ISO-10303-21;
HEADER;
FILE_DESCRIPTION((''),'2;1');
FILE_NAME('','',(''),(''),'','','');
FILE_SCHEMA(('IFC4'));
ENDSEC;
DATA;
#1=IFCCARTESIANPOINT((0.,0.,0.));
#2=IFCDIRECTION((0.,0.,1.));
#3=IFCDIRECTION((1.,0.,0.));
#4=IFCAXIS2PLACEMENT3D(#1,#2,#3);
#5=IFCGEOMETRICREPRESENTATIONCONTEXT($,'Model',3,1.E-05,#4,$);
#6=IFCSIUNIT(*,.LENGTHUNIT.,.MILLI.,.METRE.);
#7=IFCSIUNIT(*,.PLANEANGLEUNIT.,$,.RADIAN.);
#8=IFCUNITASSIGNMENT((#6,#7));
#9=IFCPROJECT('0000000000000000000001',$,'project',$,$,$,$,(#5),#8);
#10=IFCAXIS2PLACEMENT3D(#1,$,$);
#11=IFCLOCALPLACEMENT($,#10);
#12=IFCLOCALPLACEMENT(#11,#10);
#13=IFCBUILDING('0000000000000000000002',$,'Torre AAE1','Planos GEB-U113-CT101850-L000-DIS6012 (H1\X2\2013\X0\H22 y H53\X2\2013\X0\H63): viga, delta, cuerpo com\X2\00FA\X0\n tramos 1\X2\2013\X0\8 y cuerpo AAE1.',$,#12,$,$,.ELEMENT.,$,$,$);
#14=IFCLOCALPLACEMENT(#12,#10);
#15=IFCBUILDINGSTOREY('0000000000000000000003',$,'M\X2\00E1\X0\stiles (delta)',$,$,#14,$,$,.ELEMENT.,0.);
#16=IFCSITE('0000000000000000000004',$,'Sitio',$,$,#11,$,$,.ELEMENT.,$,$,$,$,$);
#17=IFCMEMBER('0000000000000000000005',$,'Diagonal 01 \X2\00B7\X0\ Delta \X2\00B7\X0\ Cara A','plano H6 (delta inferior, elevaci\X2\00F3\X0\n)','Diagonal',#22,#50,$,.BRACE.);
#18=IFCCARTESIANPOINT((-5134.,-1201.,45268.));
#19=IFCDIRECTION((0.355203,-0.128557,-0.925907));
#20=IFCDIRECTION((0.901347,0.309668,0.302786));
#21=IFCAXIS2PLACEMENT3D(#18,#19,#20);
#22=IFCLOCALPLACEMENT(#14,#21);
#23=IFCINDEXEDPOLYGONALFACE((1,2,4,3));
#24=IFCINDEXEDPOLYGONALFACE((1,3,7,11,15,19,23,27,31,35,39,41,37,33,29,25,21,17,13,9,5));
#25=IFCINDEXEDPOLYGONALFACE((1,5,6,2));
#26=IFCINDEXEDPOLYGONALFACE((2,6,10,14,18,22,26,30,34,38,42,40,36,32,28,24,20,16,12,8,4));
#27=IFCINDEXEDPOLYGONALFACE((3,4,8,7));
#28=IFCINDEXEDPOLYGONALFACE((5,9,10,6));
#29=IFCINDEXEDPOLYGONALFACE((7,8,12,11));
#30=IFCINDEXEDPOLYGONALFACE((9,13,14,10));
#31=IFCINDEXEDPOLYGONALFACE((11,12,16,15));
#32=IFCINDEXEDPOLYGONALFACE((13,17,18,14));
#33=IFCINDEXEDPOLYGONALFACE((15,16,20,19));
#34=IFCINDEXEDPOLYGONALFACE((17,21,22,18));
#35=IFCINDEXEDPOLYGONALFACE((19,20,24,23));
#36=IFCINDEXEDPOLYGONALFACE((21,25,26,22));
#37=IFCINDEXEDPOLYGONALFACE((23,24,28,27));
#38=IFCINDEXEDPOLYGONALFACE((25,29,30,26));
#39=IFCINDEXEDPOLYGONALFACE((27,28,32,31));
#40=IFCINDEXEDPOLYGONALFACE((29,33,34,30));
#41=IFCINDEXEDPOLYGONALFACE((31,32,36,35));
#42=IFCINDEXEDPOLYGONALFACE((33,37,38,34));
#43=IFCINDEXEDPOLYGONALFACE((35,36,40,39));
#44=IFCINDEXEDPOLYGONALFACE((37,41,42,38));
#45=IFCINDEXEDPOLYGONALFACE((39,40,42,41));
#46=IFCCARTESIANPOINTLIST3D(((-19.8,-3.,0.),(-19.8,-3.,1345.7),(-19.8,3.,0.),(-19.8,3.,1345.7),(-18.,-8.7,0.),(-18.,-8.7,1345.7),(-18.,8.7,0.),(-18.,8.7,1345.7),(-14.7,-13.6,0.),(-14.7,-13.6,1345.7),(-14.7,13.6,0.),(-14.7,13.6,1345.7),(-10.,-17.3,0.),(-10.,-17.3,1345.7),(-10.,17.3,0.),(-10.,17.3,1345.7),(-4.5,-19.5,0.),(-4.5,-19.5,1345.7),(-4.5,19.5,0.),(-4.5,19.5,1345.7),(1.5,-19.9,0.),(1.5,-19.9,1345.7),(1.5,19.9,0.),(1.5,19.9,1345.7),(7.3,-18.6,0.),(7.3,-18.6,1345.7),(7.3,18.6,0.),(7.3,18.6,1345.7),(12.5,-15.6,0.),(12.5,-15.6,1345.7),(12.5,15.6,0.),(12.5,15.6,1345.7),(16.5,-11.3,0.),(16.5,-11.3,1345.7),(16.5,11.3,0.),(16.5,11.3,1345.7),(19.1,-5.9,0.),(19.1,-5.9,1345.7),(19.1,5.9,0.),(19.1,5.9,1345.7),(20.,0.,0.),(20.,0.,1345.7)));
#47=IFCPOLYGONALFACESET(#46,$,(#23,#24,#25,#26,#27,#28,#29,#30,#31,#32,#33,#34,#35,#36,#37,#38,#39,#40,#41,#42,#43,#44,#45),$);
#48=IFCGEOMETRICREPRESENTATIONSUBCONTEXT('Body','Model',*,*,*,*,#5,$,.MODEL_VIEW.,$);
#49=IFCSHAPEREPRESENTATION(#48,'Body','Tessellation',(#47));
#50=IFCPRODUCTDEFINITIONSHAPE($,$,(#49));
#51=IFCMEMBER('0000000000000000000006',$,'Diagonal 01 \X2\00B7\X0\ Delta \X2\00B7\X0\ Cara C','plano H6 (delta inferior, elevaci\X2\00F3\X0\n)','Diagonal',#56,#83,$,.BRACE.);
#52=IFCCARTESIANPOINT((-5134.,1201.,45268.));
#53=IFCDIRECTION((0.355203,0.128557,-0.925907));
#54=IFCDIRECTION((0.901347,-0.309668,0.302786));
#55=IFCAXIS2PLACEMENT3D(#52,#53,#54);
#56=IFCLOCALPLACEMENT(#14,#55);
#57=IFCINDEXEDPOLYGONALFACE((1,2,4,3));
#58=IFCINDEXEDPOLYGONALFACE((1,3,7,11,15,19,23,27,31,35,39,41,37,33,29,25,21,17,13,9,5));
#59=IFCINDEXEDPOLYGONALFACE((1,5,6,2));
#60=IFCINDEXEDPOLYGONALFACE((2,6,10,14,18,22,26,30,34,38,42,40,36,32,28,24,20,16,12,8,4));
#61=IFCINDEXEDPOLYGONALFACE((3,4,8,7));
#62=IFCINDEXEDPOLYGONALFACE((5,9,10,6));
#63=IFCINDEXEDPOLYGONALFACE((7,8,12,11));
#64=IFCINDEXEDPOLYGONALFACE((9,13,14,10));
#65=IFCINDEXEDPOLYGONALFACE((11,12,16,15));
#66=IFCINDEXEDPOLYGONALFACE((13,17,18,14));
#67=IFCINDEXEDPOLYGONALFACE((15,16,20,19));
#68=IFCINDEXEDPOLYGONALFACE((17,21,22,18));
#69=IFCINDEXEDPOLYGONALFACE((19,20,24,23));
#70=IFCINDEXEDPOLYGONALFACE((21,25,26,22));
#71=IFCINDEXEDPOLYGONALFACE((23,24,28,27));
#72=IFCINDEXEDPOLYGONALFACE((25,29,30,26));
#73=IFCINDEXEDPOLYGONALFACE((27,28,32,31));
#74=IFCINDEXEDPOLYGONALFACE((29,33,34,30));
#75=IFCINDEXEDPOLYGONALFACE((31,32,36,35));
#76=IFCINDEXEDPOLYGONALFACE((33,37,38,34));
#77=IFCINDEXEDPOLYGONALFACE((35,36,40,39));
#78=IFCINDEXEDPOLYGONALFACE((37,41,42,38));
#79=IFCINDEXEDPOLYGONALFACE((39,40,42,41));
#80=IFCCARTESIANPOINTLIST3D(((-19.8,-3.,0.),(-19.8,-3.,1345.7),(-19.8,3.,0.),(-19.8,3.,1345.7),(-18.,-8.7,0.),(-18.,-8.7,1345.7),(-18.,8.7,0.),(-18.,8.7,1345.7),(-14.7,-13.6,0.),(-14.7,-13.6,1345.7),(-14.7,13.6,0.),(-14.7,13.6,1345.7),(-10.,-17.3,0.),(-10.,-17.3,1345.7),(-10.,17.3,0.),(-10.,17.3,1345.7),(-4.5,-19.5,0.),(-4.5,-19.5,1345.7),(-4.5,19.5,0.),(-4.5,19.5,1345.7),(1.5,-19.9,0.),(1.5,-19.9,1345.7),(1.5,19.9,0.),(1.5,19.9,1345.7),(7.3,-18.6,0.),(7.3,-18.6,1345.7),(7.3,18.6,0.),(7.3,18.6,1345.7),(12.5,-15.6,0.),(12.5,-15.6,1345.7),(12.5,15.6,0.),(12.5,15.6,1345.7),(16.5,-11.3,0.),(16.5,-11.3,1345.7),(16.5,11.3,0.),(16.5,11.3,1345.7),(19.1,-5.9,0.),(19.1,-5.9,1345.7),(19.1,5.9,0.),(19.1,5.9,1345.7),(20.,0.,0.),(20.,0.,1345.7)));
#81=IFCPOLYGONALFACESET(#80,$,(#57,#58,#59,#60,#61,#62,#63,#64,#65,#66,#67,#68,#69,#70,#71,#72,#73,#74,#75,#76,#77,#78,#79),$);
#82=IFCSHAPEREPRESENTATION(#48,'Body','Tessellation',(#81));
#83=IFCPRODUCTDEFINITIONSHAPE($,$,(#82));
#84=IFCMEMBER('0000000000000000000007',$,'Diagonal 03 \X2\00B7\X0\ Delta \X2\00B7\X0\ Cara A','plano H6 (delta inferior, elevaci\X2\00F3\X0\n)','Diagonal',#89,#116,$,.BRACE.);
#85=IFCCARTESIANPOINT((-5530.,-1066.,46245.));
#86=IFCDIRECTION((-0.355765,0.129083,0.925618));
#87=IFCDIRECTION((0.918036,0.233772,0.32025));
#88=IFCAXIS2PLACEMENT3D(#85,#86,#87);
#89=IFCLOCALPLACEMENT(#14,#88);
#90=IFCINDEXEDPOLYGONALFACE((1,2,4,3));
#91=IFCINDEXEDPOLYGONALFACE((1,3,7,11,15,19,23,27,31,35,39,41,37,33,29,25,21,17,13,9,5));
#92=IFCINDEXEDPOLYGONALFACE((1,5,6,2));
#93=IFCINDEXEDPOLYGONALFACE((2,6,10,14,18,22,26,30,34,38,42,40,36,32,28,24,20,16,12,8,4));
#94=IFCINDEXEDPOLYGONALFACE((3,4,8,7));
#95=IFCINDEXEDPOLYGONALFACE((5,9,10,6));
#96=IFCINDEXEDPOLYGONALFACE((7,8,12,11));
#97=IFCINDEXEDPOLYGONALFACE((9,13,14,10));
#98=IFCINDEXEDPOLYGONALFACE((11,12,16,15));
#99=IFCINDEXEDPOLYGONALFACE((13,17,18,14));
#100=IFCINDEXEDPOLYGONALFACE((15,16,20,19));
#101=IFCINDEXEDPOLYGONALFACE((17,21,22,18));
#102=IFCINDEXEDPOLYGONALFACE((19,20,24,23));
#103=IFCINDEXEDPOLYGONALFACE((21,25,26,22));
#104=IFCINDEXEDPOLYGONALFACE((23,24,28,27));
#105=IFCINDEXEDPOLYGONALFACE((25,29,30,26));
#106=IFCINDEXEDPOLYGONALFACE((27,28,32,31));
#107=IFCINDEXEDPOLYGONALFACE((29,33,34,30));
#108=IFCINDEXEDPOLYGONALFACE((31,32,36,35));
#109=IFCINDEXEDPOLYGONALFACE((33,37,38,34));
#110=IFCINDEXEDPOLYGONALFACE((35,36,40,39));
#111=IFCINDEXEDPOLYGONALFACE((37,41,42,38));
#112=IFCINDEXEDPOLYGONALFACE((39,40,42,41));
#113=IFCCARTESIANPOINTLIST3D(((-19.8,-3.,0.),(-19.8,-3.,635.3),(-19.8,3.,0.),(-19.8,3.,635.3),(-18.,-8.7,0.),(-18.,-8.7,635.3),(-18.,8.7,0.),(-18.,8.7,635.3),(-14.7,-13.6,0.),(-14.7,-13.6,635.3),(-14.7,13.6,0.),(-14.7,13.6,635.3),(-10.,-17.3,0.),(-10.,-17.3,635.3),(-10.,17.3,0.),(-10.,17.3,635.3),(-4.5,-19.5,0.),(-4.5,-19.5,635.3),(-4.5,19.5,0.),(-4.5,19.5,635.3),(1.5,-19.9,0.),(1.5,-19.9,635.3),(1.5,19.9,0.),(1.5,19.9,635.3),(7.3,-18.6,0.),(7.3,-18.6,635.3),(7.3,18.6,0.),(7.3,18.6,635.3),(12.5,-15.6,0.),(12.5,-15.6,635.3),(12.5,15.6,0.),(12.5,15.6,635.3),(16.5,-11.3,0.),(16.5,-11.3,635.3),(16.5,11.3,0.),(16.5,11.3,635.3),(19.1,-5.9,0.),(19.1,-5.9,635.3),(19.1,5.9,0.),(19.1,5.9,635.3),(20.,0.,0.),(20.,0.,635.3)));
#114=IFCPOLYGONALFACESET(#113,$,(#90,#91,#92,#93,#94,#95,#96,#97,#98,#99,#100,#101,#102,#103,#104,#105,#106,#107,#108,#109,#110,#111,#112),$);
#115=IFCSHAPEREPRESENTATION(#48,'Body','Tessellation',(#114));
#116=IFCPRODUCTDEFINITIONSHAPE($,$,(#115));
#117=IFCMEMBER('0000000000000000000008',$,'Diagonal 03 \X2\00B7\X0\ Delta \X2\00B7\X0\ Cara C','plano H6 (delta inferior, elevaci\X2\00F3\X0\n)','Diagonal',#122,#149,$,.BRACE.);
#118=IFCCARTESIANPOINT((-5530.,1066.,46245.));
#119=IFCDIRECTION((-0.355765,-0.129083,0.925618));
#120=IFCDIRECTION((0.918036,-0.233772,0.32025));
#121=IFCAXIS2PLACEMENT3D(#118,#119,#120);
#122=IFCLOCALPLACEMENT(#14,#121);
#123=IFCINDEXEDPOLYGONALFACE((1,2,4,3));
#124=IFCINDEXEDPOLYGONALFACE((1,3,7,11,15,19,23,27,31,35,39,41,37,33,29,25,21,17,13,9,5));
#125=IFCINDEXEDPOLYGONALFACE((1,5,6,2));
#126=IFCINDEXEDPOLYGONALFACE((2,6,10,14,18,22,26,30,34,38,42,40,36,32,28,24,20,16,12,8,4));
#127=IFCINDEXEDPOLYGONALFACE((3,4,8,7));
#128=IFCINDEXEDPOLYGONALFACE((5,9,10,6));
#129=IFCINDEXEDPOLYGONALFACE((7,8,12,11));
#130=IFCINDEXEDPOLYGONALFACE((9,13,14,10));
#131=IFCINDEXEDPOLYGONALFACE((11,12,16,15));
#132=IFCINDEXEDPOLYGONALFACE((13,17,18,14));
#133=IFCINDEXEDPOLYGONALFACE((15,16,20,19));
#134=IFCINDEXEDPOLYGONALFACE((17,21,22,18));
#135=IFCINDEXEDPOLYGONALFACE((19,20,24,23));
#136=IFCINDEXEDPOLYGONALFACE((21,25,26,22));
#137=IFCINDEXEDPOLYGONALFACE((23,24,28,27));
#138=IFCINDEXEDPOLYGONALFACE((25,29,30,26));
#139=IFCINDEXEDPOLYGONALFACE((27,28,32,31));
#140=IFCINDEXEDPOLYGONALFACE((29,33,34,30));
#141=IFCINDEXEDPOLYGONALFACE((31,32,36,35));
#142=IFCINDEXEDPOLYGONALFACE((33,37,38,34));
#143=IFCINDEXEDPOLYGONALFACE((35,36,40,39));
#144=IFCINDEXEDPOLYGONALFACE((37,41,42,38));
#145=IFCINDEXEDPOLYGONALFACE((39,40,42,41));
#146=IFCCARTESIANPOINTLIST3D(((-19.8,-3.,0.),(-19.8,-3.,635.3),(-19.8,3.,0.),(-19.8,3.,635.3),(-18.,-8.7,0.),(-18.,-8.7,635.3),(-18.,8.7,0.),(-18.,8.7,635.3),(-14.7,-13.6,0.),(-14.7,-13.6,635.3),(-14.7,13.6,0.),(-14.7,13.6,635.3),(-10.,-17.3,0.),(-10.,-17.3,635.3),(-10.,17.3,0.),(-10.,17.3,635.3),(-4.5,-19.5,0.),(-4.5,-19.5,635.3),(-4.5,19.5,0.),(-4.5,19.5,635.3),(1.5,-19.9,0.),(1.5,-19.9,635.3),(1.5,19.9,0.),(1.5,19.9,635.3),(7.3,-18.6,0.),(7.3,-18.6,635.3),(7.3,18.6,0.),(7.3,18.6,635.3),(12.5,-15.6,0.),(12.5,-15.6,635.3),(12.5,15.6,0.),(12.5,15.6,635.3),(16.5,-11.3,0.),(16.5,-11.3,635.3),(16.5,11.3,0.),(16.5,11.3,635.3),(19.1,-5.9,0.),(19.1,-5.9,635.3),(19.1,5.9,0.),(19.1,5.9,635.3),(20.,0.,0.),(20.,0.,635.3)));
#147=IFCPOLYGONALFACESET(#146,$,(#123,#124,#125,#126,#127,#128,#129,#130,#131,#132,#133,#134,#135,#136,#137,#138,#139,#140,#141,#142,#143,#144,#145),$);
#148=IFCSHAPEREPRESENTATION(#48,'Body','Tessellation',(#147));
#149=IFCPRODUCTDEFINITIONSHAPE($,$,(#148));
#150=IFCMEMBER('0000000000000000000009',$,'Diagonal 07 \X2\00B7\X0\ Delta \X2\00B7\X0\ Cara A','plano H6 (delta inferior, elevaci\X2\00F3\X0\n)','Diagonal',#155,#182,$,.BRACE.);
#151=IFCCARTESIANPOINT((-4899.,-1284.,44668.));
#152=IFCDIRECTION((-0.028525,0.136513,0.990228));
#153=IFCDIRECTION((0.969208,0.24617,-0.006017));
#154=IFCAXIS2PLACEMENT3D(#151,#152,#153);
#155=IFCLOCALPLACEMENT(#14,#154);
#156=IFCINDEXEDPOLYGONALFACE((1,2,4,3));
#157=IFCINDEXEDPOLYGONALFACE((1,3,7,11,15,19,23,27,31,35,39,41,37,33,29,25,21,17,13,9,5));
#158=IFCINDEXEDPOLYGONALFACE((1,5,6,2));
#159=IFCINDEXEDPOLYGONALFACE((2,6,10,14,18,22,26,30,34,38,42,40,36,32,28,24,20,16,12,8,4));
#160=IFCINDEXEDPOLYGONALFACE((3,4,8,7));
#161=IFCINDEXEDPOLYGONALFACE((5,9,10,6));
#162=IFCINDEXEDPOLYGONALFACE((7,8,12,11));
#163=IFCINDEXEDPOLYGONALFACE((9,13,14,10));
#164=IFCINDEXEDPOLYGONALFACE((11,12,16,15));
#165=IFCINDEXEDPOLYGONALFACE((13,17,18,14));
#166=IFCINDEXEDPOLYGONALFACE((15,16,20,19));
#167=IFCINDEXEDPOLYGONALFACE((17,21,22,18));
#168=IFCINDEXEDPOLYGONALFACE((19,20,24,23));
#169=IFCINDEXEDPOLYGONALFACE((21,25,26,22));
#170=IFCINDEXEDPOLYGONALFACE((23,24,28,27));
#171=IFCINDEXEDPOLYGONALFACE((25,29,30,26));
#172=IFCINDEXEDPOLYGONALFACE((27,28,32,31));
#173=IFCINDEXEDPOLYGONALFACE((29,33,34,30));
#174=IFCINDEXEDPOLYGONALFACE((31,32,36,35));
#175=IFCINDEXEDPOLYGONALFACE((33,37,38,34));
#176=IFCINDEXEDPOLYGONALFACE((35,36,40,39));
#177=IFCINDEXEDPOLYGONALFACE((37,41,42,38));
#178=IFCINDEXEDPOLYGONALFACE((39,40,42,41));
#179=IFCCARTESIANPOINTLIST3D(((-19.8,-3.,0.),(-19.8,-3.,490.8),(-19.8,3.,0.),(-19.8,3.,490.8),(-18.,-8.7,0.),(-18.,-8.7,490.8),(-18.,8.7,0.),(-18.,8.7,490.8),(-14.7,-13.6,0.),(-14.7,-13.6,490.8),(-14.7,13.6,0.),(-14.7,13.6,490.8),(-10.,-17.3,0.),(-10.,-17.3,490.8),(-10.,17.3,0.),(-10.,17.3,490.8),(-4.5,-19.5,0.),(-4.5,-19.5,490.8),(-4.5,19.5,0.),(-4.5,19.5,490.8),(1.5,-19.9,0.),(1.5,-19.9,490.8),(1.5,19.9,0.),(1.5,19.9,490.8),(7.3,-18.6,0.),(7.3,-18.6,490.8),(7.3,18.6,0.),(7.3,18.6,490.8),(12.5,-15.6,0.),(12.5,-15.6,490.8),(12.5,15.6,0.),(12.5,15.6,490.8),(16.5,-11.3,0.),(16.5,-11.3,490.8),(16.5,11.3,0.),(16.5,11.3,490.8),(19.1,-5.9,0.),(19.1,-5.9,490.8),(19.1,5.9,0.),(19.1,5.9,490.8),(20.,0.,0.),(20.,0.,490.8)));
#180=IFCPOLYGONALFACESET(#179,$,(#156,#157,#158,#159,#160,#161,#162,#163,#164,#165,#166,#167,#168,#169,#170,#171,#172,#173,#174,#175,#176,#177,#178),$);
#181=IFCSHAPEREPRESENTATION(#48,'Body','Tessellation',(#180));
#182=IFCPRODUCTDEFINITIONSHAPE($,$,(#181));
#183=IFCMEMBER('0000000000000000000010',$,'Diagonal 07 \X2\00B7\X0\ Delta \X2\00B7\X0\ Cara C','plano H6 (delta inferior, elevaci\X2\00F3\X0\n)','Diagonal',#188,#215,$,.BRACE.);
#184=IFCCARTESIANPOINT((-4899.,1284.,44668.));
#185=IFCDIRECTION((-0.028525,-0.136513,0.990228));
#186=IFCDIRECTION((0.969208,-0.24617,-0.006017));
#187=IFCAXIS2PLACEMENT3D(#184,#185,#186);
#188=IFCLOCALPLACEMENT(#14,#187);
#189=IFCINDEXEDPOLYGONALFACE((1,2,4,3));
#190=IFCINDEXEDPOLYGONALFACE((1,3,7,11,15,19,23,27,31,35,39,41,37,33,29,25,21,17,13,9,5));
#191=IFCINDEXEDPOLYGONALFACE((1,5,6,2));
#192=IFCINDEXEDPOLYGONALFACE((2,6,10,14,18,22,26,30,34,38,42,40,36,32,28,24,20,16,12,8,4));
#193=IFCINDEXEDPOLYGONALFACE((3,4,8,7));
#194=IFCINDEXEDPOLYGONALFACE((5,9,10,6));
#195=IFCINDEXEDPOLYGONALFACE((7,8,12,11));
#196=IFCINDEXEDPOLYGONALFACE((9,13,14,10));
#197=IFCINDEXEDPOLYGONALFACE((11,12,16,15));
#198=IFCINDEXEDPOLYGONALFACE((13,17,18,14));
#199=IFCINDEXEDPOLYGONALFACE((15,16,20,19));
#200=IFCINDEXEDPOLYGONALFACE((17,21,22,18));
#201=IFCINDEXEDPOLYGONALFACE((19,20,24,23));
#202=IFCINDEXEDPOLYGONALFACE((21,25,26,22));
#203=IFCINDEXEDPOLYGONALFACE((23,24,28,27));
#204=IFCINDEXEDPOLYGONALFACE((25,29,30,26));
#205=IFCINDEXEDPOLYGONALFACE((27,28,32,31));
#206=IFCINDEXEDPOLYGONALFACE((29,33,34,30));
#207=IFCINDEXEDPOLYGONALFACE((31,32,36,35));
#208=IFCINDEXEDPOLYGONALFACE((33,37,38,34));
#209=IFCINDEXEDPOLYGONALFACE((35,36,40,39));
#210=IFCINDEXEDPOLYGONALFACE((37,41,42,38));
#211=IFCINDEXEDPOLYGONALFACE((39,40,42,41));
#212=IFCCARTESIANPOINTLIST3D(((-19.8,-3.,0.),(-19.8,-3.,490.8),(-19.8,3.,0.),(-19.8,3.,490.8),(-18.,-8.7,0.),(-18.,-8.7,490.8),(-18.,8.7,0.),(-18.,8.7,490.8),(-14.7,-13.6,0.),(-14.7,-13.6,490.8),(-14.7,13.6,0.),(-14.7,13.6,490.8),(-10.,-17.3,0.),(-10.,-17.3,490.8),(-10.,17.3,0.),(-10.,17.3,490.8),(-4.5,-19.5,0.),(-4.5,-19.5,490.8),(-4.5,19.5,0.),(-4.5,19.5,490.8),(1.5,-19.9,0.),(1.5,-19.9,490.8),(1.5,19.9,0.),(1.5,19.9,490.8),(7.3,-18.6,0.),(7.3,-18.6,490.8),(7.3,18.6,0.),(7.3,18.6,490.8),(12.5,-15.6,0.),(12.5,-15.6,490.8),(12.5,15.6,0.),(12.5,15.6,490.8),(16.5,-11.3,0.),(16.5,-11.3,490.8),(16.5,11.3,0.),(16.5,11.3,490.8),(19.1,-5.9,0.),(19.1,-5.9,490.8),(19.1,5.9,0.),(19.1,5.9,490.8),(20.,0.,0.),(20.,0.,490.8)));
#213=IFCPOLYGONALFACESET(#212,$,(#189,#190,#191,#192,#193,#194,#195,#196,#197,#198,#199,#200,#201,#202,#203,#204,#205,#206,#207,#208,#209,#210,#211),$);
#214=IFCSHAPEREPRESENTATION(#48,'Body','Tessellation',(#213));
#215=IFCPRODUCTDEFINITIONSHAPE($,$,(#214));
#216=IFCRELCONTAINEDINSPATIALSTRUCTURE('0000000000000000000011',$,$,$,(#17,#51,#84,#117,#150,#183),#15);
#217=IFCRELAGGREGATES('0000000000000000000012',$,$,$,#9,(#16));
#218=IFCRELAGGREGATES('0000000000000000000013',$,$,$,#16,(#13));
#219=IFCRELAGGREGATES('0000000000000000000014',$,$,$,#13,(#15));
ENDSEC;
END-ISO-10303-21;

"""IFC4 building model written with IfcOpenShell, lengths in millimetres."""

from ifc_helpers import new_model, si_unit, frame, origin, origin_with_axes, place, context, subcontext, project, spatial, circle, extrude, element, save


model = new_model("IFC4")

# Units and contexts
model_context = context("Model", 3, precision=1e-05, world=origin_with_axes())
body_context = subcontext(model_context, "Body", "Model", "MODEL_VIEW")
ifc_project = project(units=[si_unit("LENGTHUNIT", "METRE", prefix="MILLI"), si_unit("PLANEANGLEUNIT", "RADIAN")], contexts=[model_context])

# Site, building, storey
site_placement = place(None, origin())
site = spatial("IfcSite", under=ifc_project, at=site_placement, Name="Sitio", CompositionType="ELEMENT")
building_placement = place(site_placement, origin())
building = spatial("IfcBuilding", under=site, at=building_placement, Name="Torre AAE1", Description="Planos GEB-U113-CT101850-L000-DIS6012 (H1–H22 y H53–H63): viga, delta, cuerpo común tramos 1–8 y cuerpo AAE1.", CompositionType="ELEMENT")
storey_placement = place(building_placement, origin())
storey = spatial("IfcBuildingStorey", under=building, at=storey_placement, Name="Mástiles (delta)", CompositionType="ELEMENT", Elevation=0.0)

# Members
for number, where, z_axis, x_axis, name in (
    (1, (-5134.0, -1201.0, 45268.0), (0.355203, -0.128557, -0.925907), (0.901347, 0.309668, 0.302786), "Diagonal 01 · Delta · Cara A"),
    (2, (-5134.0, 1201.0, 45268.0), (0.355203, 0.128557, -0.925907), (0.901347, -0.309668, 0.302786), "Diagonal 01 · Delta · Cara C"),
):
    element("IfcMember", number, at=place(storey_placement, frame(where, z_axis=z_axis, x_axis=x_axis)), inside=storey, Name=name, Description="plano H6 (delta inferior, elevación)", ObjectType="Diagonal", PredefinedType="BRACE", context=body_context, shape_type="SweptSolid", body=[
        extrude(circle(Radius=20.0), None, (0.0, 0.0, 1.0), 1345.7),
    ])
for number, where, z_axis, x_axis, name in (
    (3, (-5530.0, -1066.0, 46245.0), (-0.355765, 0.129083, 0.925618), (0.918036, 0.233772, 0.32025), "Diagonal 03 · Delta · Cara A"),
    (4, (-5530.0, 1066.0, 46245.0), (-0.355765, -0.129083, 0.925618), (0.918036, -0.233772, 0.32025), "Diagonal 03 · Delta · Cara C"),
):
    element("IfcMember", number, at=place(storey_placement, frame(where, z_axis=z_axis, x_axis=x_axis)), inside=storey, Name=name, Description="plano H6 (delta inferior, elevación)", ObjectType="Diagonal", PredefinedType="BRACE", context=body_context, shape_type="SweptSolid", body=[
        extrude(circle(Radius=20.0), None, (0.0, 0.0, 1.0), 635.3),
    ])
for number, where, z_axis, x_axis, name in (
    (5, (-4899.0, -1284.0, 44668.0), (-0.028525, 0.136513, 0.990228), (0.969208, 0.24617, -0.006017), "Diagonal 07 · Delta · Cara A"),
    (6, (-4899.0, 1284.0, 44668.0), (-0.028525, -0.136513, 0.990228), (0.969208, -0.24617, -0.006017), "Diagonal 07 · Delta · Cara C"),
):
    element("IfcMember", number, at=place(storey_placement, frame(where, z_axis=z_axis, x_axis=x_axis)), inside=storey, Name=name, Description="plano H6 (delta inferior, elevación)", ObjectType="Diagonal", PredefinedType="BRACE", context=body_context, shape_type="SweptSolid", body=[
        extrude(circle(Radius=20.0), None, (0.0, 0.0, 1.0), 490.8),
    ])

save(model, "model.ifc")
